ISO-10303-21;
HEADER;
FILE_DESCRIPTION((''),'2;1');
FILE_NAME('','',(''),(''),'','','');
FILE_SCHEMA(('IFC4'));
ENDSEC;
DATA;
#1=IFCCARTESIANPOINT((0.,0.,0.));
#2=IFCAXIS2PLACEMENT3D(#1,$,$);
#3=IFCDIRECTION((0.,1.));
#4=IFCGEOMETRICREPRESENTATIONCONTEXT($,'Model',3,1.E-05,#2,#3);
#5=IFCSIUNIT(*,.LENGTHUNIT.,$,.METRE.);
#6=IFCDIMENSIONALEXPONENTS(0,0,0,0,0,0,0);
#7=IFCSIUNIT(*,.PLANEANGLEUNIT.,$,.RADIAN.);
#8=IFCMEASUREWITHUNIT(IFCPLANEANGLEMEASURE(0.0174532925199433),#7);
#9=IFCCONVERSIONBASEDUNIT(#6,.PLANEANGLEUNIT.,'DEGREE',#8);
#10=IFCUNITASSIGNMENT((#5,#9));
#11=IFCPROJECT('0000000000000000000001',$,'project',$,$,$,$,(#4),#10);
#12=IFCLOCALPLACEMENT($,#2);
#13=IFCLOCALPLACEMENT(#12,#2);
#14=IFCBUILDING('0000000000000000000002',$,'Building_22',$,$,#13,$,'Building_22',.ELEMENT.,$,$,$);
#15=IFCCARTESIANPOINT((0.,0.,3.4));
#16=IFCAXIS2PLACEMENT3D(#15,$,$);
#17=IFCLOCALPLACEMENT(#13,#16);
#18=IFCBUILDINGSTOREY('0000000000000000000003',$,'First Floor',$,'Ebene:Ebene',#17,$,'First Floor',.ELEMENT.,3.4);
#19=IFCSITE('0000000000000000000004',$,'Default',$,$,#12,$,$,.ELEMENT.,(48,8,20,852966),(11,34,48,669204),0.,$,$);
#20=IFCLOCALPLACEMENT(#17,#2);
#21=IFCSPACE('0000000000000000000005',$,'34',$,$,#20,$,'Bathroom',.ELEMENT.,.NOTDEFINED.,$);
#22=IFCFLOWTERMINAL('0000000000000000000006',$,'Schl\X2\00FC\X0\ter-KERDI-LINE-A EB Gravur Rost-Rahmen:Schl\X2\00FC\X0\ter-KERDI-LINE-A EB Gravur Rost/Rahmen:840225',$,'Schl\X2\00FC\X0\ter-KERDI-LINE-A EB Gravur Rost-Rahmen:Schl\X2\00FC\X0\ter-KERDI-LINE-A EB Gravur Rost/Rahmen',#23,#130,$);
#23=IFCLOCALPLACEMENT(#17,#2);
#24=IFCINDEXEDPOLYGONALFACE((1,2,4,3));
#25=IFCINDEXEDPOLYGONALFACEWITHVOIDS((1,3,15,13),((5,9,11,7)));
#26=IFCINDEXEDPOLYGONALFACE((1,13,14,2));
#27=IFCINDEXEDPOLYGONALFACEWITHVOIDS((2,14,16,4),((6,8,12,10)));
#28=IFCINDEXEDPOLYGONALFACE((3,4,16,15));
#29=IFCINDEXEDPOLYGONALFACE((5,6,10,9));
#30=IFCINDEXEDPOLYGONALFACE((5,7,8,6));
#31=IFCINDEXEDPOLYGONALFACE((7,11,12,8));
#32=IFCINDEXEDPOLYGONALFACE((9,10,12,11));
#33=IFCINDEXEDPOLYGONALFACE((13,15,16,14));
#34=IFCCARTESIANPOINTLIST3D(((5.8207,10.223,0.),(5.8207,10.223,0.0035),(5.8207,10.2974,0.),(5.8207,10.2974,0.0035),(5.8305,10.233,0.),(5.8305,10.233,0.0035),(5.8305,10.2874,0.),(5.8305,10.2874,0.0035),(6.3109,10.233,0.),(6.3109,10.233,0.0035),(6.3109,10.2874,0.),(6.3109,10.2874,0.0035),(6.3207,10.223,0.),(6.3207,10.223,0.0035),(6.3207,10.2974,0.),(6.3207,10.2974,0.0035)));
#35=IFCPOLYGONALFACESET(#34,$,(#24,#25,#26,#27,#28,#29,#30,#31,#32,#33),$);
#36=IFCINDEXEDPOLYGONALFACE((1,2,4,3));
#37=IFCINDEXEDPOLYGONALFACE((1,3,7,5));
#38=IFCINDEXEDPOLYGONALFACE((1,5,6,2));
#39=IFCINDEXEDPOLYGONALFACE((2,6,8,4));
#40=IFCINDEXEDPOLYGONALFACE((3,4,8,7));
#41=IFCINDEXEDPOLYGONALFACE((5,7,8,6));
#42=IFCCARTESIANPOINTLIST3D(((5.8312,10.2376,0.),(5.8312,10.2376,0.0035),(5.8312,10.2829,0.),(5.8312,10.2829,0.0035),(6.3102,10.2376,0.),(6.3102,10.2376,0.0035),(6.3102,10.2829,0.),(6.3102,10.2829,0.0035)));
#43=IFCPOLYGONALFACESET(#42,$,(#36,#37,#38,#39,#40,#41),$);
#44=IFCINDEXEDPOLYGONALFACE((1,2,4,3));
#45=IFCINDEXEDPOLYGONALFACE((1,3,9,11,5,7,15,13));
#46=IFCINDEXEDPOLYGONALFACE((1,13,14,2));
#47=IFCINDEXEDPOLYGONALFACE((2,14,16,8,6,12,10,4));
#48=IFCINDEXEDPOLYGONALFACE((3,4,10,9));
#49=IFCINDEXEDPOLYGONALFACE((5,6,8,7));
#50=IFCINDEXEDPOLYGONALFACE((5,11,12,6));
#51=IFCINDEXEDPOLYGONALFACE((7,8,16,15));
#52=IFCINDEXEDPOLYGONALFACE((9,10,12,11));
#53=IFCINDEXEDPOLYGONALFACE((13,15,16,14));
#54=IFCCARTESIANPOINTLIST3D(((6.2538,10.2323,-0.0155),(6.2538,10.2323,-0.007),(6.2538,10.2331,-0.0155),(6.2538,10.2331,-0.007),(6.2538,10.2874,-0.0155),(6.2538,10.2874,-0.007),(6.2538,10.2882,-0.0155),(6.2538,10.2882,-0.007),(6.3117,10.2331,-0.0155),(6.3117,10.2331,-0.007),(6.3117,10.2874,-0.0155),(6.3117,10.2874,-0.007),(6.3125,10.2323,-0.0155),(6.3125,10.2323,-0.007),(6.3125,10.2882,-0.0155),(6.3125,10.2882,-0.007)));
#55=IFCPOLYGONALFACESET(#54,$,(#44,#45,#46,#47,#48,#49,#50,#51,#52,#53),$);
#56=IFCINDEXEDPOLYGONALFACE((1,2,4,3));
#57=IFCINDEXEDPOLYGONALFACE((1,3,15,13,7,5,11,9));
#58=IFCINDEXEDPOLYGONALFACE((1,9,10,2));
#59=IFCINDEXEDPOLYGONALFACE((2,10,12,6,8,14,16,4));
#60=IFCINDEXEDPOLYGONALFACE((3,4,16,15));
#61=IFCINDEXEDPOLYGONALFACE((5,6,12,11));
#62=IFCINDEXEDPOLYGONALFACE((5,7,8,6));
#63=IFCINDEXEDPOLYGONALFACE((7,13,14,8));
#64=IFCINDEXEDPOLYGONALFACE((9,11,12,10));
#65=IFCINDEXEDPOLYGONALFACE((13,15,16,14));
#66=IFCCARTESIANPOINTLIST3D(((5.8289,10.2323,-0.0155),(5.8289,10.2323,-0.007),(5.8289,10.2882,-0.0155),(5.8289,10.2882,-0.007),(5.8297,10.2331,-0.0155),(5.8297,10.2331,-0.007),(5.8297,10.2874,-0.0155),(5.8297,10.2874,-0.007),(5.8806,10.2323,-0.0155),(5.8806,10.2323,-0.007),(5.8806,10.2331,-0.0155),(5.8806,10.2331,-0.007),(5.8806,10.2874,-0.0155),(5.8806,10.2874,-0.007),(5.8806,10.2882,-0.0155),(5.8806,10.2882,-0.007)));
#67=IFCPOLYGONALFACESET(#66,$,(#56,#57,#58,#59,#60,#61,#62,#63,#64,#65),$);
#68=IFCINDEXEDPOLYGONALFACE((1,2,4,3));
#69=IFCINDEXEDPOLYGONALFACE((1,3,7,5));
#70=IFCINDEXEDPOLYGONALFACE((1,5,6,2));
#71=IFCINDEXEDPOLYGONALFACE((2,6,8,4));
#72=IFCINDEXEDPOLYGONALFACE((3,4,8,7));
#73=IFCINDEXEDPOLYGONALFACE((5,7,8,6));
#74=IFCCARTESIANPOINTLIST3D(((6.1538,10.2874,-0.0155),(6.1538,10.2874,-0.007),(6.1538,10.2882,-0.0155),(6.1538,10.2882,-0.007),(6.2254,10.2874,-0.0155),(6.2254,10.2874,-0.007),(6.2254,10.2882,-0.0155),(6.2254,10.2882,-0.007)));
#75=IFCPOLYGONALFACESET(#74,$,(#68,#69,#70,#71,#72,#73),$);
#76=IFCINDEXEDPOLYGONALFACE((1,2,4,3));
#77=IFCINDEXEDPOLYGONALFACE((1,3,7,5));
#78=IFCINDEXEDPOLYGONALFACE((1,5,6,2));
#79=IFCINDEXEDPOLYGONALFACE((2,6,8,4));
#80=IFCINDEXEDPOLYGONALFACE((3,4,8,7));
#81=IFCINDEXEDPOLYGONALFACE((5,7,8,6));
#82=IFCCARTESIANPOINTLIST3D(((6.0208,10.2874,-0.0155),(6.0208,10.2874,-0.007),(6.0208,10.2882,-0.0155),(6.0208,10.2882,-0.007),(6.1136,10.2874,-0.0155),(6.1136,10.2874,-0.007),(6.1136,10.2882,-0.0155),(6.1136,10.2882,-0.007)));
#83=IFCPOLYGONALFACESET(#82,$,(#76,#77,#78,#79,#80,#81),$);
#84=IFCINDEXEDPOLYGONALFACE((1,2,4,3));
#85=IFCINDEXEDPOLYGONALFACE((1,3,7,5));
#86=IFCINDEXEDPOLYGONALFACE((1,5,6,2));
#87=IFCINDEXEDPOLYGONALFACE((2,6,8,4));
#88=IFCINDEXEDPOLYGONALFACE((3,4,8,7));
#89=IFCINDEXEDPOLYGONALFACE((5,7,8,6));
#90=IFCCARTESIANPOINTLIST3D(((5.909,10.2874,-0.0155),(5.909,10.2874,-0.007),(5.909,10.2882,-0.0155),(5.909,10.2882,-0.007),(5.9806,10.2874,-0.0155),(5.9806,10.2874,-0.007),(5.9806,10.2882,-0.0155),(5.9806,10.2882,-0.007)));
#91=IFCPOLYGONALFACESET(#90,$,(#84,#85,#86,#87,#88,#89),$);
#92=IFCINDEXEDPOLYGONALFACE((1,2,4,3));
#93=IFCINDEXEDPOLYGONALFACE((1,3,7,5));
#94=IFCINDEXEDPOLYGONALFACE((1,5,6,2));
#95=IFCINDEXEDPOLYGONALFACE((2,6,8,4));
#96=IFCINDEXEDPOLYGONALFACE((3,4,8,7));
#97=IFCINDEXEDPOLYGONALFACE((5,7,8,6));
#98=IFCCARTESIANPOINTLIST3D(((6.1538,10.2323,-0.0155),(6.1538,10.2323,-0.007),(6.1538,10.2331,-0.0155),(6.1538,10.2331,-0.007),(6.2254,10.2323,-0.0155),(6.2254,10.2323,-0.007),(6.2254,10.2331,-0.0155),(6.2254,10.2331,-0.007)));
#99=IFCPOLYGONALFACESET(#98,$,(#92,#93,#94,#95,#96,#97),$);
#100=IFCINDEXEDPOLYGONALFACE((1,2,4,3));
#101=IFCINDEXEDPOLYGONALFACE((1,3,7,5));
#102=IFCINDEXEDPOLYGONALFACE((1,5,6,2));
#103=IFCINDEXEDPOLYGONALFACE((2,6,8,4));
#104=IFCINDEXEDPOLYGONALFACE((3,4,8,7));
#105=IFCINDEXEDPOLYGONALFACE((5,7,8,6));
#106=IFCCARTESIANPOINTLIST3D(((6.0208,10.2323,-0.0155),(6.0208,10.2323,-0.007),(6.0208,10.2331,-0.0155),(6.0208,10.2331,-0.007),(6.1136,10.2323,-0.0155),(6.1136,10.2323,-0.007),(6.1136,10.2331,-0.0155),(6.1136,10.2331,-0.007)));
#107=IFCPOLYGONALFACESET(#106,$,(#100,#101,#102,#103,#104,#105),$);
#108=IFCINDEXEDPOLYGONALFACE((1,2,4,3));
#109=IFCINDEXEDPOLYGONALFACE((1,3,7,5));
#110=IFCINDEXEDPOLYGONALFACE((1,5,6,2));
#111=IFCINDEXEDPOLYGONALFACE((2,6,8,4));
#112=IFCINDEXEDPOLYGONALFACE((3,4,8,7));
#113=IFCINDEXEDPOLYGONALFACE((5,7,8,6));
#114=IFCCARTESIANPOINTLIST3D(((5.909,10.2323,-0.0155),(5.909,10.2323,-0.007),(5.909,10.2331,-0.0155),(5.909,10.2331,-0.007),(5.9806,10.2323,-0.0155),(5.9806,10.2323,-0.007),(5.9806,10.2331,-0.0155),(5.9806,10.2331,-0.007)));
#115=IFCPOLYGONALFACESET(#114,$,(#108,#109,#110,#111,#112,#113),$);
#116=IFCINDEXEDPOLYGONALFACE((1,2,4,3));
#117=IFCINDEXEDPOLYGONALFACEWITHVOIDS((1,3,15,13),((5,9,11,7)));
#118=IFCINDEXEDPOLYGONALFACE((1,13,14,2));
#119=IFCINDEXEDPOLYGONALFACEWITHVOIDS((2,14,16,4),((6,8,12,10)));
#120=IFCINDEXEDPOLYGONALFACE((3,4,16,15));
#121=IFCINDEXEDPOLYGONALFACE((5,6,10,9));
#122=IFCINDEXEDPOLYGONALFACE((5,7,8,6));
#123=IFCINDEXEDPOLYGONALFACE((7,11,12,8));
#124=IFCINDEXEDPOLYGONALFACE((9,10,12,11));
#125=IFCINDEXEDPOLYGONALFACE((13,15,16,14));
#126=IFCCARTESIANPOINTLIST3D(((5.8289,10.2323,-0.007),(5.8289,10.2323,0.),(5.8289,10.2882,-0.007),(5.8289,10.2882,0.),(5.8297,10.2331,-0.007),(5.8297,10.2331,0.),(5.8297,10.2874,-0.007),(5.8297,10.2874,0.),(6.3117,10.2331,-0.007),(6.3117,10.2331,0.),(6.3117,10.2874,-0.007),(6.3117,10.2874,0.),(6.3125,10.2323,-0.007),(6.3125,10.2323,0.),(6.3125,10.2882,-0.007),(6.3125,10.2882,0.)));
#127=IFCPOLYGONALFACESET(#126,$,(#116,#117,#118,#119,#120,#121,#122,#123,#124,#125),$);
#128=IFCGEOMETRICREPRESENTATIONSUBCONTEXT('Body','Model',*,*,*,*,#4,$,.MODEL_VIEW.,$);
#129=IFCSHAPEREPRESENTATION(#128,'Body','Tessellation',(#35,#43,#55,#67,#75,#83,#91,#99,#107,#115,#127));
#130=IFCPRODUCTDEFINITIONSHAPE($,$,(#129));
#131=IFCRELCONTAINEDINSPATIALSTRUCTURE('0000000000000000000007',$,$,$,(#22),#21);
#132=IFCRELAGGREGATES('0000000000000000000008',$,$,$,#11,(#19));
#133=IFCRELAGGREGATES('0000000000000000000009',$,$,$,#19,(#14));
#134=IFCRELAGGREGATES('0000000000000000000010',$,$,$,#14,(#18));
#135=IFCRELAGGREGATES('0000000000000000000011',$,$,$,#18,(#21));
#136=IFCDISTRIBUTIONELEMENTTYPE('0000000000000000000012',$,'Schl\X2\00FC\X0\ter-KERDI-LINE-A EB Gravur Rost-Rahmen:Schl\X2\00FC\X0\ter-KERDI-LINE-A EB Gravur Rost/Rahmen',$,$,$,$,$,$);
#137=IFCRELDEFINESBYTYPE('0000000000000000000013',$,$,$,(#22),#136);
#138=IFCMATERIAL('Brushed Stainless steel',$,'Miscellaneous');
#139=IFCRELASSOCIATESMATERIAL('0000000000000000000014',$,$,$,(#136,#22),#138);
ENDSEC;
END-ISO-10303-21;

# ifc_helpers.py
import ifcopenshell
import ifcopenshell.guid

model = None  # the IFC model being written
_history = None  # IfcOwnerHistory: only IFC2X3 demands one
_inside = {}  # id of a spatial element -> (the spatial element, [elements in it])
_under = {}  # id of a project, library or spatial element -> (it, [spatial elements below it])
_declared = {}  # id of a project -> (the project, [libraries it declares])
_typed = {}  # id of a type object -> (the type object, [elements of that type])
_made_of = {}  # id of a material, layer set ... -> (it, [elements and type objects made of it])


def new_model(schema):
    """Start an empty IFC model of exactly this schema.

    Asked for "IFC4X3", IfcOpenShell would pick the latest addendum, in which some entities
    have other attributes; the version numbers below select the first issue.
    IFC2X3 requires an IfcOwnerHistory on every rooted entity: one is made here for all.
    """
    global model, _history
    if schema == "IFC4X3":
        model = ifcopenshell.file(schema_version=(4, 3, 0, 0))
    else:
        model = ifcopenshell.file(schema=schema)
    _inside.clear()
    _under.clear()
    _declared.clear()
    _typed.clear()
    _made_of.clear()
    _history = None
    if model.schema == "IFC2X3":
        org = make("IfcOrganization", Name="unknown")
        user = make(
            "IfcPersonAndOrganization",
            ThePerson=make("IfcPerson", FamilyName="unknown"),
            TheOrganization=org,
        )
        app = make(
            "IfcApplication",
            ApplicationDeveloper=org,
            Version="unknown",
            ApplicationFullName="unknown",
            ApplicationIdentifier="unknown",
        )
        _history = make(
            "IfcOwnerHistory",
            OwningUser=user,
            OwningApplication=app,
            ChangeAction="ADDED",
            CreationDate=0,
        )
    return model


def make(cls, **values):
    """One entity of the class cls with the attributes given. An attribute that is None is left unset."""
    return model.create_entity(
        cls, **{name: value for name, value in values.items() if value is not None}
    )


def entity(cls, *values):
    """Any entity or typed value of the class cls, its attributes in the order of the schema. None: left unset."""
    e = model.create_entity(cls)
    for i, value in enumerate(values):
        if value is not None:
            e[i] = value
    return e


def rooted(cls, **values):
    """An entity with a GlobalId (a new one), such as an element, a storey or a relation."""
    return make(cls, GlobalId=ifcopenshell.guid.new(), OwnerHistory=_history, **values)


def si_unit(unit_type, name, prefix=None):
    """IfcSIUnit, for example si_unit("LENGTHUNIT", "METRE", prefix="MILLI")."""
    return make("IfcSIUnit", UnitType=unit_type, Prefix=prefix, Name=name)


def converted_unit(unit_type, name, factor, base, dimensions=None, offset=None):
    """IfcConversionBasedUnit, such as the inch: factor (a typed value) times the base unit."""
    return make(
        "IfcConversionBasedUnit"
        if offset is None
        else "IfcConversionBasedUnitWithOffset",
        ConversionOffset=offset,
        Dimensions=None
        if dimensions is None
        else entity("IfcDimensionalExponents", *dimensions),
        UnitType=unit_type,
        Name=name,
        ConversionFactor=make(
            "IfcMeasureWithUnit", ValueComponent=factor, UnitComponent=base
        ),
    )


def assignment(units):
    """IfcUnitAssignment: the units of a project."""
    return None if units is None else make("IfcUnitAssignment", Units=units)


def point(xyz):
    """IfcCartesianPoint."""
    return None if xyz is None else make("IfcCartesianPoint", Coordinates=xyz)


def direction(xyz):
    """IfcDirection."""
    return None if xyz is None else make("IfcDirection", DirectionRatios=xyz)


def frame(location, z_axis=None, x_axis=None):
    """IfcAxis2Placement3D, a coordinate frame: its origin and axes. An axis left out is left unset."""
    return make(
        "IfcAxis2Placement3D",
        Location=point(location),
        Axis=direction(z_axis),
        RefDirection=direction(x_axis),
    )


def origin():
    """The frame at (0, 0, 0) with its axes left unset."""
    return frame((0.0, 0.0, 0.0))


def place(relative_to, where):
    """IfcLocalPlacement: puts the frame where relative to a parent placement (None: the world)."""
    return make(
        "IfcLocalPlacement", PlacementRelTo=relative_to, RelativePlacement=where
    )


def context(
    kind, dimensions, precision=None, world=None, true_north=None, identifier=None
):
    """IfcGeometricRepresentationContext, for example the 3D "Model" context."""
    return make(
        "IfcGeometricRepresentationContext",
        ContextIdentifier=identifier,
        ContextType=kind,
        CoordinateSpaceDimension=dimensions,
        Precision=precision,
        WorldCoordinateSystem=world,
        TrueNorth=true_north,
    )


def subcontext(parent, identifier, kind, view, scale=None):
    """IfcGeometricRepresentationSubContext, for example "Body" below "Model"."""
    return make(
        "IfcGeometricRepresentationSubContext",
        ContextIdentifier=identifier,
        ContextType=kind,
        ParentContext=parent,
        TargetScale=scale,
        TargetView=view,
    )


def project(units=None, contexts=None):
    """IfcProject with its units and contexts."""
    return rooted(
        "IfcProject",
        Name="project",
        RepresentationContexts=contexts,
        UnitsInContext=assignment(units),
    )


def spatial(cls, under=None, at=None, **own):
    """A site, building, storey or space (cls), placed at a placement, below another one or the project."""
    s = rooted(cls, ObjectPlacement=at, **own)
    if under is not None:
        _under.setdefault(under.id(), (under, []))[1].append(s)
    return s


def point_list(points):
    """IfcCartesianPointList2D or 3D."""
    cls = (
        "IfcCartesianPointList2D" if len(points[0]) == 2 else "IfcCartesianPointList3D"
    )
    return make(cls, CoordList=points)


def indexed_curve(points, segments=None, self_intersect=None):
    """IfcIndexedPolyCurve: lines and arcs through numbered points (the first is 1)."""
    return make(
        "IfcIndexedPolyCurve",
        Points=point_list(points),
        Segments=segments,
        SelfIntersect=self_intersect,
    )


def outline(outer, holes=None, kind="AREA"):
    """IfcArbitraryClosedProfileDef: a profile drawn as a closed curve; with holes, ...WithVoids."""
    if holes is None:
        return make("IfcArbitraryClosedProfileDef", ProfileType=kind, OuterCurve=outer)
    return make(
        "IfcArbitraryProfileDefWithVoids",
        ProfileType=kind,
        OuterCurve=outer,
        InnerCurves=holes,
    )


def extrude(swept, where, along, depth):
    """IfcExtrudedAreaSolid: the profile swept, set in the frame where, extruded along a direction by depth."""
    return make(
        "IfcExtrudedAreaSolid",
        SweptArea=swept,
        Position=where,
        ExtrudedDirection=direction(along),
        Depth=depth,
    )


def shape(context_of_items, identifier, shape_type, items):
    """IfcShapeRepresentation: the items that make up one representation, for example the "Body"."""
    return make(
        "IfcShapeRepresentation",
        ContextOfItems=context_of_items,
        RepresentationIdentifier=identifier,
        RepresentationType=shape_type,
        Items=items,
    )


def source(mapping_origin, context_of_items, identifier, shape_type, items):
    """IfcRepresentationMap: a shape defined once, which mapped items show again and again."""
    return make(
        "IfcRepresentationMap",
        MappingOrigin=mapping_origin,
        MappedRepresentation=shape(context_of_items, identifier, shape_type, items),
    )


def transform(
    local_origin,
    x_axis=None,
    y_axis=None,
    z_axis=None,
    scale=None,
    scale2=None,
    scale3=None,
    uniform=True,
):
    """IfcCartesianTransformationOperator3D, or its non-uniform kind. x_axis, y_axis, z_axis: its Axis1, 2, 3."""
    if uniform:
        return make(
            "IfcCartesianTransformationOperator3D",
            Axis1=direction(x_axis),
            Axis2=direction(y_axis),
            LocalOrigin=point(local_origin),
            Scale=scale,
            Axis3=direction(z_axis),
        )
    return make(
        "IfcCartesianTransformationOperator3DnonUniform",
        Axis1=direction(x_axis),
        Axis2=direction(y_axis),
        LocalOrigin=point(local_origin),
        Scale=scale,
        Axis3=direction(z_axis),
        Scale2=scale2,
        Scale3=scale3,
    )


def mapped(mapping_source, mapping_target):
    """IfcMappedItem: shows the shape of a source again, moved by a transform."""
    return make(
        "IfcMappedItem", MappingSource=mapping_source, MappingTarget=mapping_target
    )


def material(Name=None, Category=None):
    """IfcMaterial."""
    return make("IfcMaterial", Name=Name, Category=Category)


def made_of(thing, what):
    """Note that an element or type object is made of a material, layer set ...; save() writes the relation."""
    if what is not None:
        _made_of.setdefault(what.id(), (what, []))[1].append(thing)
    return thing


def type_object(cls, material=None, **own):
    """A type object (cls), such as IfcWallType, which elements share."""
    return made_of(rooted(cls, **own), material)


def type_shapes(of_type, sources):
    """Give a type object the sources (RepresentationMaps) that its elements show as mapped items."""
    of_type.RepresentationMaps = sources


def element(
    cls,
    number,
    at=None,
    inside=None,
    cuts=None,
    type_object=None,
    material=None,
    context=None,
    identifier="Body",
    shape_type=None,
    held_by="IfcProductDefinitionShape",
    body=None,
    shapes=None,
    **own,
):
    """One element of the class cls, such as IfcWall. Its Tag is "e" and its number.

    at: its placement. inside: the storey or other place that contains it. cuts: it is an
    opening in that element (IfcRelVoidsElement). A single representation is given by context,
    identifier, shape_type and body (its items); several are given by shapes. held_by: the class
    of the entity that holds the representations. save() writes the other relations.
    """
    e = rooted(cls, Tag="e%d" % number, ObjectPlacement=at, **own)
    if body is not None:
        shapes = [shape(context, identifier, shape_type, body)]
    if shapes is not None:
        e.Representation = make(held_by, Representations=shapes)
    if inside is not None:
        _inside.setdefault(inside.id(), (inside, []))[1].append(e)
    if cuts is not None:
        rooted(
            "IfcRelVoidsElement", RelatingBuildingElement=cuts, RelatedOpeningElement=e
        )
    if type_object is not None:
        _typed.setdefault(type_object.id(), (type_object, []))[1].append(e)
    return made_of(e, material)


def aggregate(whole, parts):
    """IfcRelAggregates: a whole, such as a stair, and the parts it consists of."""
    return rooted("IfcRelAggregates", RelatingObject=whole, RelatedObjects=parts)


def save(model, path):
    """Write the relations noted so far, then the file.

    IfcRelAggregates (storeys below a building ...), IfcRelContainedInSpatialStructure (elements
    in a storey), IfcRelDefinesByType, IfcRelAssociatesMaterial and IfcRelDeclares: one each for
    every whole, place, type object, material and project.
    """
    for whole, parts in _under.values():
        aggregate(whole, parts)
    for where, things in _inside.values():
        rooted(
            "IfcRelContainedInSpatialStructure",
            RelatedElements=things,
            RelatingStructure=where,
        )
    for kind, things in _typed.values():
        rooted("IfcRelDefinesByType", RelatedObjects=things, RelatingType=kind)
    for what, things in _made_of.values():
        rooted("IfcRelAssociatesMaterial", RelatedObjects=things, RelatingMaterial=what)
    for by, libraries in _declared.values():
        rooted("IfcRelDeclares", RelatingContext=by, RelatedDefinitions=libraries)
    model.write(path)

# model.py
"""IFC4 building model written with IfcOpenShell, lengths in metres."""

from ifc_helpers import new_model, entity, si_unit, converted_unit, direction, frame, origin, place, context, subcontext, project, spatial, indexed_curve, outline, extrude, source, transform, mapped, material, type_object, type_shapes, element, save


model = new_model("IFC4")

# Units and contexts
model_context = context("Model", 3, precision=1e-05, world=origin(), true_north=direction((0.0, 1.0)))
body_context = subcontext(model_context, "Body", "Model", "MODEL_VIEW")
ifc_project = project(units=[si_unit("LENGTHUNIT", "METRE"), converted_unit("PLANEANGLEUNIT", "DEGREE", entity("IfcPlaneAngleMeasure", 0.0174532925199433), si_unit("PLANEANGLEUNIT", "RADIAN"), dimensions=[0, 0, 0, 0, 0, 0, 0])], contexts=[model_context])

# Site, building, storey
site_placement = place(None, origin())
site = spatial("IfcSite", under=ifc_project, at=site_placement, Name="Default", CompositionType="ELEMENT", RefLatitude=(48, 8, 20, 852966), RefLongitude=(11, 34, 48, 669204), RefElevation=0.0)
building_placement = place(site_placement, origin())
building = spatial("IfcBuilding", under=site, at=building_placement, Name="Building_22", LongName="Building_22", CompositionType="ELEMENT")
storey_placement = place(building_placement, frame((0.0, 0.0, 3.4)))
storey = spatial("IfcBuildingStorey", under=building, at=storey_placement, Name="First Floor", ObjectType="Ebene:Ebene", LongName="First Floor", CompositionType="ELEMENT", Elevation=3.4)

# Shared definitions
ifc_material_1 = material(Name="Brushed Stainless steel", Category="Miscellaneous")

# Shared definitions
space_1_placement = place(storey_placement, origin())
space_1 = spatial("IfcSpace", under=storey, at=space_1_placement, Name="34", LongName="Bathroom", CompositionType="ELEMENT", PredefinedType="NOTDEFINED")

# Flow terminal
distribution_element_type_1 = type_object("IfcDistributionElementType", Name="Schlüter-KERDI-LINE-A EB Gravur Rost-Rahmen:Schlüter-KERDI-LINE-A EB Gravur Rost/Rahmen", material=ifc_material_1)
shared_shape_1 = source(origin(), body_context, "Body", "SweptSolid", [
    extrude(outline(indexed_curve([(-0.0372, -0.25), (0.0372, -0.25), (0.0372, 0.25), (-0.0372, 0.25), (-0.0372, -0.25)], self_intersect=False), holes=[indexed_curve([(0.0272, 0.2402), (0.0272, -0.2402), (-0.0272, -0.2402), (-0.0272, 0.2402), (0.0272, 0.2402)], self_intersect=False)]), frame((0.0, 0.0, 0.0), z_axis=(0.0, 0.0, 1.0), x_axis=(0.0, 1.0, 0.0)), (0.0, 0.0, 1.0), 0.0035),
    extrude(outline(indexed_curve([(-0.0227, -0.2395), (0.0227, -0.2395), (0.0227, 0.2395), (-0.0227, 0.2395), (-0.0227, -0.2395)], self_intersect=False)), frame((0.0, 0.0, 0.0), z_axis=(0.0, 0.0, 1.0), x_axis=(0.0, 1.0, 0.0)), (0.0, 0.0, 1.0), 0.0035),
    extrude(outline(indexed_curve([(-0.028, -0.0291), (-0.0272, -0.0291), (-0.0272, 0.0287), (0.0272, 0.0287), (0.0272, -0.0291), (0.028, -0.0291), (0.028, 0.0295), (-0.028, 0.0295), (-0.028, -0.0291)], self_intersect=False)), frame((-0.2123, 0.0, -0.0155), z_axis=(0.0, 0.0, 1.0), x_axis=(0.0, 1.0, 0.0)), (0.0, 0.0, 1.0), 0.0085),
    extrude(outline(indexed_curve([(-0.0252, 0.0272), (0.0256, 0.0272), (0.0256, 0.028), (-0.026, 0.028), (-0.026, -0.028), (0.0256, -0.028), (0.0256, -0.0272), (-0.0252, -0.0272), (-0.0252, 0.0272)], self_intersect=False)), frame((0.2158, 0.0, -0.0155), z_axis=(0.0, 0.0, 1.0), x_axis=(-1.0, 0.0, 0.0)), (0.0, 0.0, 1.0), 0.0085),
    extrude(outline(indexed_curve([(-0.0004, -0.0358), (0.0004, -0.0358), (0.0004, 0.0358), (-0.0004, 0.0358), (-0.0004, -0.0358)], self_intersect=False)), frame((-0.1189, -0.0276, -0.0155), z_axis=(0.0, 0.0, 1.0), x_axis=(0.0, -1.0, 0.0)), (0.0, 0.0, 1.0), 0.0085),
    extrude(outline(indexed_curve([(-0.0004, -0.0464), (0.0004, -0.0464), (0.0004, 0.0464), (-0.0004, 0.0464), (-0.0004, -0.0464)], self_intersect=False)), frame((0.0035, -0.0276, -0.0155), z_axis=(0.0, 0.0, 1.0), x_axis=(0.0, -1.0, 0.0)), (0.0, 0.0, 1.0), 0.0085),
    extrude(outline(indexed_curve([(-0.0004, -0.0358), (0.0004, -0.0358), (0.0004, 0.0358), (-0.0004, 0.0358), (-0.0004, -0.0358)], self_intersect=False)), frame((0.1259, -0.0276, -0.0155), z_axis=(0.0, 0.0, 1.0), x_axis=(0.0, -1.0, 0.0)), (0.0, 0.0, 1.0), 0.0085),
    extrude(outline(indexed_curve([(-0.0358, -0.0004), (0.0358, -0.0004), (0.0358, 0.0004), (-0.0358, 0.0004), (-0.0358, -0.0004)], self_intersect=False)), frame((-0.1189, 0.0276, -0.0155)), (0.0, 0.0, 1.0), 0.0085),
    extrude(outline(indexed_curve([(-0.0464, -0.0004), (0.0464, -0.0004), (0.0464, 0.0004), (-0.0464, 0.0004), (-0.0464, -0.0004)], self_intersect=False)), frame((0.0035, 0.0276, -0.0155)), (0.0, 0.0, 1.0), 0.0085),
    extrude(outline(indexed_curve([(-0.0358, -0.0004), (0.0358, -0.0004), (0.0358, 0.0004), (-0.0358, 0.0004), (-0.0358, -0.0004)], self_intersect=False)), frame((0.1259, 0.0276, -0.0155)), (0.0, 0.0, 1.0), 0.0085),
    extrude(outline(indexed_curve([(-0.028, -0.2418), (0.028, -0.2418), (0.028, 0.2418), (-0.028, 0.2418), (-0.028, -0.2418)], self_intersect=False), holes=[indexed_curve([(-0.0272, 0.241), (0.0272, 0.241), (0.0272, -0.241), (-0.0272, -0.241), (-0.0272, 0.241)], self_intersect=False)]), frame((0.0, 0.0, -0.007), z_axis=(0.0, 0.0, 1.0), x_axis=(0.0, 1.0, 0.0)), (0.0, 0.0, 1.0), 0.007),
])
type_shapes(distribution_element_type_1, [shared_shape_1])
flow_terminal_1_placement = place(space_1_placement, frame((6.0707, 10.2602, 0.0), z_axis=(0.0, 0.0, 1.0), x_axis=(-1.0, 0.0, 0.0)))
element("IfcFlowTerminal", 1, at=flow_terminal_1_placement, inside=space_1, type_object=distribution_element_type_1, material=ifc_material_1, Name="Schlüter-KERDI-LINE-A EB Gravur Rost-Rahmen:Schlüter-KERDI-LINE-A EB Gravur Rost/Rahmen:840225", ObjectType="Schlüter-KERDI-LINE-A EB Gravur Rost-Rahmen:Schlüter-KERDI-LINE-A EB Gravur Rost/Rahmen", context=body_context, shape_type="MappedRepresentation", body=[
    mapped(shared_shape_1, transform((0.0, 0.0, 0.0), scale=1.0)),
])

save(model, "model.ifc")
